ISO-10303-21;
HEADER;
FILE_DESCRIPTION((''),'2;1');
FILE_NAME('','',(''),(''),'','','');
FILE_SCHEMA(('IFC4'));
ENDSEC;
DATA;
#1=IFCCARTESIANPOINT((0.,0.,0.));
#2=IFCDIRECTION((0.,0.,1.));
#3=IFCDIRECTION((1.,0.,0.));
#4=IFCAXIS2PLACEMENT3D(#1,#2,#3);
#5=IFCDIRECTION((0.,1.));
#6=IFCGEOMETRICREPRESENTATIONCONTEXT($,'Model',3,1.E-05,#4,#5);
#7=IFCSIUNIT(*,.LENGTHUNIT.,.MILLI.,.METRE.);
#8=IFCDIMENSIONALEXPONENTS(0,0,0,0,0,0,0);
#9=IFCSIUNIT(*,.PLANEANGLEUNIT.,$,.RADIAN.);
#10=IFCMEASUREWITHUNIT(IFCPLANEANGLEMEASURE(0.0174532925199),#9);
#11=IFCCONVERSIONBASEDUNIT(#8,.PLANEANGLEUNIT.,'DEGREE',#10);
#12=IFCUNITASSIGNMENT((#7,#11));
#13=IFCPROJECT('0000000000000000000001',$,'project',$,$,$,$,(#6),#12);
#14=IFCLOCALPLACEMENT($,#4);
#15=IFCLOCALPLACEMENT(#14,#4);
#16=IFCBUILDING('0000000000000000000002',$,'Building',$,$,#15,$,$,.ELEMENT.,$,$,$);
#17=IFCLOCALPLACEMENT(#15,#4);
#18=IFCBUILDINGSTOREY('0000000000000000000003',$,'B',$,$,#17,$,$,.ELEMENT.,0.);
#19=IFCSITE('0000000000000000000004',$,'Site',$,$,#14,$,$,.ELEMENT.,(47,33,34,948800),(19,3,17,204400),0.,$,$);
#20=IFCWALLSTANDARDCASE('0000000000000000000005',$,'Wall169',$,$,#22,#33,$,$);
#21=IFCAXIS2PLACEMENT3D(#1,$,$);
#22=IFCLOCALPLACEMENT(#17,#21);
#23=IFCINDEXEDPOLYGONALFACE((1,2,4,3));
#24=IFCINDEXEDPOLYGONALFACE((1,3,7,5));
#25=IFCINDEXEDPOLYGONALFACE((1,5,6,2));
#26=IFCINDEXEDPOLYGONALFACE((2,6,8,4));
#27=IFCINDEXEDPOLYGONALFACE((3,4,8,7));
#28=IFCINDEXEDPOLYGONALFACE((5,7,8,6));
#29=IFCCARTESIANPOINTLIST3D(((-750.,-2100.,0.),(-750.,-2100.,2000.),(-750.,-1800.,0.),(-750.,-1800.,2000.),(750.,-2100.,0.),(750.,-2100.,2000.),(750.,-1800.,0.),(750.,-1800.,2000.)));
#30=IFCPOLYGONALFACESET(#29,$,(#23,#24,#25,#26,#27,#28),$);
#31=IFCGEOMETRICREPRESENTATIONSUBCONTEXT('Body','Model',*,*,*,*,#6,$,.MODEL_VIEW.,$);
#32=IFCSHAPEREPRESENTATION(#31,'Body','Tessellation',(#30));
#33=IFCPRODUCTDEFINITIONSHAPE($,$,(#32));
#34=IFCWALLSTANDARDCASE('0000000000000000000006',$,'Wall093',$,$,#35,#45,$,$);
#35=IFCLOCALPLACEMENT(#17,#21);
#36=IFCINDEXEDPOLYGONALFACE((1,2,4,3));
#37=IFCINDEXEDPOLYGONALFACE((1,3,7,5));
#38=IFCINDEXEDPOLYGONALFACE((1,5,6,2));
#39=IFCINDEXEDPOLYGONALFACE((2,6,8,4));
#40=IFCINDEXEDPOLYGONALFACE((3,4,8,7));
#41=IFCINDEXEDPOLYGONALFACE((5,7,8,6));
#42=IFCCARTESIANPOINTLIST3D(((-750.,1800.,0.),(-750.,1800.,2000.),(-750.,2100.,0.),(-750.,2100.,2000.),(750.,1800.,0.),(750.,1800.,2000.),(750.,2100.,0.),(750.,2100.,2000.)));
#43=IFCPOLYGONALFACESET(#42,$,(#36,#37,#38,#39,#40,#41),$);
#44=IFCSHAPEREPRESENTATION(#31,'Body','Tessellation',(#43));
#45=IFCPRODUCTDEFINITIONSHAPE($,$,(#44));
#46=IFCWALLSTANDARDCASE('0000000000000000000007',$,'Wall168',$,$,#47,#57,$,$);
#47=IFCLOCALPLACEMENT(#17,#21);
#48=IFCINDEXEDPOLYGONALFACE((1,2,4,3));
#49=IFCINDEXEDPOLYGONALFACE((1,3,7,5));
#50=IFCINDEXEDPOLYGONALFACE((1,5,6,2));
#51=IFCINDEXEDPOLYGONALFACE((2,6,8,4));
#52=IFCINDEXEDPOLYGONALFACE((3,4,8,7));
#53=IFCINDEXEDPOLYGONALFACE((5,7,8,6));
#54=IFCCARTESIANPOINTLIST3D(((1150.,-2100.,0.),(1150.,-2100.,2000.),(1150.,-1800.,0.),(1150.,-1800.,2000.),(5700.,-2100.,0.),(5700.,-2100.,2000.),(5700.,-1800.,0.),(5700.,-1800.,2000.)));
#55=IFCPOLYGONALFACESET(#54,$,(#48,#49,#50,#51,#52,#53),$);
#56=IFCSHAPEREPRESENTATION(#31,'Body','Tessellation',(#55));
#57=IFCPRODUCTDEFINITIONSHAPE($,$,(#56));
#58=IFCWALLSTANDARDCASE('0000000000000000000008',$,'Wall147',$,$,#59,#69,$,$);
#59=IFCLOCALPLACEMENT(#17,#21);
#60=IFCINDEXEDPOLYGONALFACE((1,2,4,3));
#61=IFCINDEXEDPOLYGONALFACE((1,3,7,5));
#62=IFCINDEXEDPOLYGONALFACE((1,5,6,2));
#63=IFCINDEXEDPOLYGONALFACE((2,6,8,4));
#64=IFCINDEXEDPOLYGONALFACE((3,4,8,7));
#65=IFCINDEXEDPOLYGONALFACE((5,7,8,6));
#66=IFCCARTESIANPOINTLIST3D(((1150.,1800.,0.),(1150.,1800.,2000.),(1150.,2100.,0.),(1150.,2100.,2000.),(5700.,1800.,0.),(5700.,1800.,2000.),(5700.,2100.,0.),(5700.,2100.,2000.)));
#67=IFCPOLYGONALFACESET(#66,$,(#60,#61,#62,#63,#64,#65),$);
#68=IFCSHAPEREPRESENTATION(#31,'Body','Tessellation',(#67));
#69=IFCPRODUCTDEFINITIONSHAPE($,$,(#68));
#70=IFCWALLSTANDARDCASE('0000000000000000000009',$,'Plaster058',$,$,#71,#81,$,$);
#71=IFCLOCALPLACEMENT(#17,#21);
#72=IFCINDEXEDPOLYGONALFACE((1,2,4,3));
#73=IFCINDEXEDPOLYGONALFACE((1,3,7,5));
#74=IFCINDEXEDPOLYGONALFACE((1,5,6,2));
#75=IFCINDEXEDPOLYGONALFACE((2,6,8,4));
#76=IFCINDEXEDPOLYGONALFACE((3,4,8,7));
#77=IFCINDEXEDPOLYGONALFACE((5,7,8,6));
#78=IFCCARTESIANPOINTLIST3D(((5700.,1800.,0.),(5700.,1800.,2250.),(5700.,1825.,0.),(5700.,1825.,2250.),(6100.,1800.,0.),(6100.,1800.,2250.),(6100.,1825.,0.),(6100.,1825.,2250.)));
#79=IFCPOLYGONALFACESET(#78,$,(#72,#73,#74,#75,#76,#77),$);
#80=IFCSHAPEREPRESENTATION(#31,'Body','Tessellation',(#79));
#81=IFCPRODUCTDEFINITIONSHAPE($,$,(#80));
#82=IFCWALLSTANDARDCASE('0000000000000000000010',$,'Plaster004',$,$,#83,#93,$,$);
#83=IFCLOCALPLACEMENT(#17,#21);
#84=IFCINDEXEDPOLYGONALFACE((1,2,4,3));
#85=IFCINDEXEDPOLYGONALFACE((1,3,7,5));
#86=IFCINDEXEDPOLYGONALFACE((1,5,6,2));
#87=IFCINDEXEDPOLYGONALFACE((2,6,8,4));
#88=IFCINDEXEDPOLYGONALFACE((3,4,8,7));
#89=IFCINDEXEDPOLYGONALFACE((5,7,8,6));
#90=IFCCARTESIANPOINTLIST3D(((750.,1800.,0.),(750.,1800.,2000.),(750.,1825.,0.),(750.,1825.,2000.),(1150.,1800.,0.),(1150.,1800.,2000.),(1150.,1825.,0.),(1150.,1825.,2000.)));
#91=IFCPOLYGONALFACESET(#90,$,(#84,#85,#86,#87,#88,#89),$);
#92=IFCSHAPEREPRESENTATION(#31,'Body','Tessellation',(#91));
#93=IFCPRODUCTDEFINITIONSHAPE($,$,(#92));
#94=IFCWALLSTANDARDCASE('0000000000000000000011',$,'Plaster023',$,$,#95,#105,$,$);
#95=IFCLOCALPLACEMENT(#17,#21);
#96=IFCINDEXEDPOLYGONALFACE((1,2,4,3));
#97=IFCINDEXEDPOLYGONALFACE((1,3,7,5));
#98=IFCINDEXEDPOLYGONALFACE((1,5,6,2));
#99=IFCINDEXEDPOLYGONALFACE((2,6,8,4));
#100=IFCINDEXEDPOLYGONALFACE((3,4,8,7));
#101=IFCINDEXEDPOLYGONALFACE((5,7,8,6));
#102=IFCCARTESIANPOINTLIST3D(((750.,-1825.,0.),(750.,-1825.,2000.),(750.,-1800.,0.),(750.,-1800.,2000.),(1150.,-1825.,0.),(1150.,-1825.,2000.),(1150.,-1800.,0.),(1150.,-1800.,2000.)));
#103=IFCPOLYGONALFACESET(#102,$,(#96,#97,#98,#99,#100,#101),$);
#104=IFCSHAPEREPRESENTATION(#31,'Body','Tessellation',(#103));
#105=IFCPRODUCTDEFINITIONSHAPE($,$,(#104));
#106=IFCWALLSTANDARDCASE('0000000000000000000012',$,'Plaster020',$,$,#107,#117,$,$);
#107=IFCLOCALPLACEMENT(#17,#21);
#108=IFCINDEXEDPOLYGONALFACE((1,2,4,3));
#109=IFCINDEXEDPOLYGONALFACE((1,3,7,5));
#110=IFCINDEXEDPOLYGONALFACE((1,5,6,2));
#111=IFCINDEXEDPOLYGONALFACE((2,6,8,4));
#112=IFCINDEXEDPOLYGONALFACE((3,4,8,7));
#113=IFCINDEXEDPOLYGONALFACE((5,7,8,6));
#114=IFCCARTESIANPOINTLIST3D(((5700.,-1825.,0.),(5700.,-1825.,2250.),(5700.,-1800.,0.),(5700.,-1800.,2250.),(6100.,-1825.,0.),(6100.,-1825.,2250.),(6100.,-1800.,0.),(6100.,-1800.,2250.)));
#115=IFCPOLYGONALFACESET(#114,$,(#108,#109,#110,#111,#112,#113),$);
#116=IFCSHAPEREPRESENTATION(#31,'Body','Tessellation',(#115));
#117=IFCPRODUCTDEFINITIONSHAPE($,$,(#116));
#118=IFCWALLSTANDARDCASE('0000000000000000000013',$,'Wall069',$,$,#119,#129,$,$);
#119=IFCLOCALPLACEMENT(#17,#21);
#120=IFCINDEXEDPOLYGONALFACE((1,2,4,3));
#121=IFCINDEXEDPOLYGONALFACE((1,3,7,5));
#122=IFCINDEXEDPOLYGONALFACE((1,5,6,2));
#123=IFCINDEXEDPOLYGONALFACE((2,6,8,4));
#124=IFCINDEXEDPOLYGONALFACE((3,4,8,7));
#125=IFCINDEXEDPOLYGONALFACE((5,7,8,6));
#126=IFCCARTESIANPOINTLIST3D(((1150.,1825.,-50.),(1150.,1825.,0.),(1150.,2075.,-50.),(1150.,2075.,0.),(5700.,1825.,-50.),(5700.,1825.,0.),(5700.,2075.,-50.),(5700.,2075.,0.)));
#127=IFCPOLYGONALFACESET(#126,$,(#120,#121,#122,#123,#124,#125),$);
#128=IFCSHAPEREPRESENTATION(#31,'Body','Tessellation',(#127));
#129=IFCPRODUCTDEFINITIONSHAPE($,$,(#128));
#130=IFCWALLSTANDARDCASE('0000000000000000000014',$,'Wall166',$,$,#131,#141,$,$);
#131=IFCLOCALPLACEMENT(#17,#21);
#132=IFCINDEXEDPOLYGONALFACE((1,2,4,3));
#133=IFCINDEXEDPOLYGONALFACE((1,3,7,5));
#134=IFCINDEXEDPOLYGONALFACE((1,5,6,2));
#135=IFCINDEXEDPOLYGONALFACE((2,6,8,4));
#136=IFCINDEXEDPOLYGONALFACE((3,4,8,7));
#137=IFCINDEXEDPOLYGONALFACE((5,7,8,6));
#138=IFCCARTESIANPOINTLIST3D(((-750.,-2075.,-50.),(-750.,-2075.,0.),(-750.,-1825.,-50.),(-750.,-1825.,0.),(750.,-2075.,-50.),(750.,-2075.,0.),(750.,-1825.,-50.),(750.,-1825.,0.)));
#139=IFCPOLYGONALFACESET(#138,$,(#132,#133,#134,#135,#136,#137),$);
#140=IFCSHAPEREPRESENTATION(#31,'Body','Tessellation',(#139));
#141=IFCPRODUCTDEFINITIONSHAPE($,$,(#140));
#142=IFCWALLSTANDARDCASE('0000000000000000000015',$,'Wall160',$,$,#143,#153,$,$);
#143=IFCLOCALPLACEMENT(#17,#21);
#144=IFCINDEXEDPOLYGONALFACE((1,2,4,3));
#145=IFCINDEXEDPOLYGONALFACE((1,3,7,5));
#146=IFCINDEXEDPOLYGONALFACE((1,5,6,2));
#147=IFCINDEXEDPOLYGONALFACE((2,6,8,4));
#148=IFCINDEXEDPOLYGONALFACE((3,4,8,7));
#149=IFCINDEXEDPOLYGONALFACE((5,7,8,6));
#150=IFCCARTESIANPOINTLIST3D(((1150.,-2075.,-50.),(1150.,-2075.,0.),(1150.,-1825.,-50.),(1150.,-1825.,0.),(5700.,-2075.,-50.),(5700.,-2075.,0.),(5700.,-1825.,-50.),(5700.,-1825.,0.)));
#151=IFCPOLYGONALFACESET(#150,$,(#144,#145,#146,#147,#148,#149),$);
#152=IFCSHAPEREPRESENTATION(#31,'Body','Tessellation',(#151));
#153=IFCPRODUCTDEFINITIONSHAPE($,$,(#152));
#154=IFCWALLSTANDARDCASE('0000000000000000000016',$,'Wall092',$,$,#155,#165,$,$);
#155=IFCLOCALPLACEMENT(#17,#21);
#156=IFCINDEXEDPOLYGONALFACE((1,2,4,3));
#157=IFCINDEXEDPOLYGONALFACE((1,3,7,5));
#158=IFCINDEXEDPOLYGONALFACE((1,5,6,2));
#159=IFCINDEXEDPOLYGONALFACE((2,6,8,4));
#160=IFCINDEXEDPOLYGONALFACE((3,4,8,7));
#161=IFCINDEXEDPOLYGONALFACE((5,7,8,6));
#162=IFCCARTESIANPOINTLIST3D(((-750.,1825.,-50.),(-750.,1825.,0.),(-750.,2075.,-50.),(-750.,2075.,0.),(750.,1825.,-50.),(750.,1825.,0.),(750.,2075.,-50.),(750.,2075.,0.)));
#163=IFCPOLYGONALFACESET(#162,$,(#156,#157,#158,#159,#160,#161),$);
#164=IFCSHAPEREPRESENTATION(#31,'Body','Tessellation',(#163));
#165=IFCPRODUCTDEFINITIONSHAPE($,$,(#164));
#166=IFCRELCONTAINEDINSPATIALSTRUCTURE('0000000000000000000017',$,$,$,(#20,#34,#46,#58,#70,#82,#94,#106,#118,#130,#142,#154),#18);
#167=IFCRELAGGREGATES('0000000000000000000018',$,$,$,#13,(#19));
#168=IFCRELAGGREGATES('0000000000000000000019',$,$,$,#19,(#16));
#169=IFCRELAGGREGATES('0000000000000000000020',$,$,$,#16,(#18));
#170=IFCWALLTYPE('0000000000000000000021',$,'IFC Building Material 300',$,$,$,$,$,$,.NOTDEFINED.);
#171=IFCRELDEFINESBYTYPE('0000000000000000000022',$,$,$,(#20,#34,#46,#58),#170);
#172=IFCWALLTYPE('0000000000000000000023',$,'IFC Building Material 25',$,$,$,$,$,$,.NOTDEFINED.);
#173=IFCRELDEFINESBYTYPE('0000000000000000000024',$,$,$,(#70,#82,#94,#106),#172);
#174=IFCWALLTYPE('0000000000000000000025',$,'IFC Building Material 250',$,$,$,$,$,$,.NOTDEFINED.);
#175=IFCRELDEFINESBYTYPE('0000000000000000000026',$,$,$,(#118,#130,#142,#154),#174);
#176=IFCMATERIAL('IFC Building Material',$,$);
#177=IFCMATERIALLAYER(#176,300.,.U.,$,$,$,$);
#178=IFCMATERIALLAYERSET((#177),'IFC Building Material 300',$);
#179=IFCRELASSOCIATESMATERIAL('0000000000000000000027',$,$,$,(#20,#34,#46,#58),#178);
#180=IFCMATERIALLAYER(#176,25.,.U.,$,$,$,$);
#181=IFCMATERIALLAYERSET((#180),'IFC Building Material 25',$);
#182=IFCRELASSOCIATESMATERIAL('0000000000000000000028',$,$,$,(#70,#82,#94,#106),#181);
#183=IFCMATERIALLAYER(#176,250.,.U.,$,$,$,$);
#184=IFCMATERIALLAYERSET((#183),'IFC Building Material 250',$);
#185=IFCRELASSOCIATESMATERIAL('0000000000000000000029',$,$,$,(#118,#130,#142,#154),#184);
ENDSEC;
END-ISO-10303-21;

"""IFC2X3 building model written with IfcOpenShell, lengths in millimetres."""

from ifc_helpers import new_model, entity, si_unit, converted_unit, direction, frame, origin_with_axes, place, context, subcontext, project, spatial, polyline, outline, extrude, material, layer, layer_set, layer_usage, type_object, element, save


model = new_model("IFC2X3")

# Units and contexts
model_context = context("Model", 3, precision=1e-05, world=origin_with_axes(), true_north=direction((0.0, 1.0)))
body_context = subcontext(model_context, "Body", "Model", "MODEL_VIEW")
ifc_project = project(units=[si_unit("LENGTHUNIT", "METRE", prefix="MILLI"), converted_unit("PLANEANGLEUNIT", "DEGREE", entity("IfcPlaneAngleMeasure", 0.0174532925199), si_unit("PLANEANGLEUNIT", "RADIAN"), dimensions=[0, 0, 0, 0, 0, 0, 0])], contexts=[model_context])

# Site, building, storey
site_placement = place(None, origin_with_axes())
site = spatial("IfcSite", under=ifc_project, at=site_placement, Name="Site", CompositionType="ELEMENT", RefLatitude=(47, 33, 34, 948800), RefLongitude=(19, 3, 17, 204400), RefElevation=0.0)
building_placement = place(site_placement, origin_with_axes())
building = spatial("IfcBuilding", under=site, at=building_placement, Name="Building", CompositionType="ELEMENT")
storey_placement = place(building_placement, origin_with_axes())
storey = spatial("IfcBuildingStorey", under=building, at=storey_placement, Name="B", CompositionType="ELEMENT", Elevation=0.0)

# Shared definitions
ifc_material = material(Name="IFC Building Material")

# Shared definitions
ifc_layer_1 = layer(ifc_material, 250.0, ventilated="UNKNOWN")
ifc_layer_set_1 = layer_set([ifc_layer_1], Name="IFC Building Material 250")

# Walls
ifc_layer_2 = layer(ifc_material, 300.0, ventilated="UNKNOWN")
ifc_layer_set_2 = layer_set([ifc_layer_2], Name="IFC Building Material 300")
ifc_layer_usage_1 = layer_usage(ifc_layer_set_2, "AXIS2", "POSITIVE", -300.0)
wall_type_1 = type_object("IfcWallType", Name="IFC Building Material 300", PredefinedType="NOTDEFINED")
wall_1_placement = place(storey_placement, frame((-750.0, -1800.0, 0.0), z_axis=(0.0, 0.0, 1.0), x_axis=(1.0, 0.0, 0.0)))
element("IfcWallStandardCase", 1, at=wall_1_placement, inside=storey, type_object=wall_type_1, material=ifc_layer_usage_1, Name="Wall169", context=body_context, shape_type="SweptSolid", body=[
    extrude(outline(polyline([(0.0, -300.0), (1500.0, -300.0), (1500.0, 0.0), (0.0, 0.0), (0.0, -300.0)])), origin_with_axes(), (0.0, 0.0, 1.0), 2000.0),
])
ifc_layer_usage_2 = layer_usage(ifc_layer_set_2, "AXIS2", "POSITIVE", 0.0)
wall_2_placement = place(storey_placement, frame((-750.0, 1800.0, 0.0), z_axis=(0.0, 0.0, 1.0), x_axis=(1.0, 0.0, 0.0)))
element("IfcWallStandardCase", 2, at=wall_2_placement, inside=storey, type_object=wall_type_1, material=ifc_layer_usage_2, Name="Wall093", context=body_context, shape_type="SweptSolid", body=[
    extrude(outline(polyline([(0.0, 0.0), (1500.0, 0.0), (1500.0, 300.0), (0.0, 300.0), (0.0, 0.0)])), origin_with_axes(), (0.0, 0.0, 1.0), 2000.0),
])
ifc_layer_usage_3 = layer_usage(ifc_layer_set_2, "AXIS2", "POSITIVE", 0.0)
wall_3_placement = place(storey_placement, frame((5700.0, -1800.0, 0.0), z_axis=(0.0, 0.0, 1.0), x_axis=(-1.0, 0.0, 0.0)))
element("IfcWallStandardCase", 3, at=wall_3_placement, inside=storey, type_object=wall_type_1, material=ifc_layer_usage_3, Name="Wall168", context=body_context, shape_type="SweptSolid", body=[
    extrude(outline(polyline([(0.0, 0.0), (4550.0, 0.0), (4550.0, 300.0), (0.0, 300.0), (0.0, 0.0)])), origin_with_axes(), (0.0, 0.0, 1.0), 2000.0),
])
ifc_layer_usage_4 = layer_usage(ifc_layer_set_2, "AXIS2", "POSITIVE", -300.0)
wall_4_placement = place(storey_placement, frame((5700.0, 1800.0, 0.0), z_axis=(0.0, 0.0, 1.0), x_axis=(-1.0, 0.0, 0.0)))
element("IfcWallStandardCase", 4, at=wall_4_placement, inside=storey, type_object=wall_type_1, material=ifc_layer_usage_4, Name="Wall147", context=body_context, shape_type="SweptSolid", body=[
    extrude(outline(polyline([(0.0, -300.0), (4550.0, -300.0), (4550.0, 0.0), (0.0, 0.0), (0.0, -300.0)])), origin_with_axes(), (0.0, 0.0, 1.0), 2000.0),
])
ifc_layer_3 = layer(ifc_material, 25.0, ventilated="UNKNOWN")
ifc_layer_set_3 = layer_set([ifc_layer_3], Name="IFC Building Material 25")
ifc_layer_usage_5 = layer_usage(ifc_layer_set_3, "AXIS2", "POSITIVE", 0.0)
wall_type_2 = type_object("IfcWallType", Name="IFC Building Material 25", PredefinedType="NOTDEFINED")
wall_5_placement = place(storey_placement, frame((5700.0, 1800.0, 0.0), z_axis=(0.0, 0.0, 1.0), x_axis=(1.0, 0.0, 0.0)))
element("IfcWallStandardCase", 5, at=wall_5_placement, inside=storey, type_object=wall_type_2, material=ifc_layer_usage_5, Name="Plaster058", context=body_context, shape_type="SweptSolid", body=[
    extrude(outline(polyline([(0.0, 0.0), (400.0, 0.0), (400.0, 25.0), (0.0, 25.0), (0.0, 0.0)])), origin_with_axes(), (0.0, 0.0, 1.0), 2250.0),
])
ifc_layer_usage_6 = layer_usage(ifc_layer_set_3, "AXIS2", "POSITIVE", 0.0)
wall_6_placement = place(storey_placement, frame((750.0, 1800.0, 0.0), z_axis=(0.0, 0.0, 1.0), x_axis=(1.0, 0.0, 0.0)))
element("IfcWallStandardCase", 6, at=wall_6_placement, inside=storey, type_object=wall_type_2, material=ifc_layer_usage_6, Name="Plaster004", context=body_context, shape_type="SweptSolid", body=[
    extrude(outline(polyline([(0.0, 0.0), (400.0, 0.0), (400.0, 25.0), (0.0, 25.0), (0.0, 0.0)])), origin_with_axes(), (0.0, 0.0, 1.0), 2000.0),
])
ifc_layer_usage_7 = layer_usage(ifc_layer_set_3, "AXIS2", "POSITIVE", -25.0)
wall_7_placement = place(storey_placement, frame((750.0, -1800.0, 0.0), z_axis=(0.0, 0.0, 1.0), x_axis=(1.0, 0.0, 0.0)))
element("IfcWallStandardCase", 7, at=wall_7_placement, inside=storey, type_object=wall_type_2, material=ifc_layer_usage_7, Name="Plaster023", context=body_context, shape_type="SweptSolid", body=[
    extrude(outline(polyline([(0.0, -25.0), (400.0, -25.0), (400.0, 0.0), (0.0, 0.0), (0.0, -25.0)])), origin_with_axes(), (0.0, 0.0, 1.0), 2000.0),
])
ifc_layer_usage_8 = layer_usage(ifc_layer_set_3, "AXIS2", "POSITIVE", -25.0)
wall_8_placement = place(storey_placement, frame((5700.0, -1800.0, 0.0), z_axis=(0.0, 0.0, 1.0), x_axis=(1.0, 0.0, 0.0)))
element("IfcWallStandardCase", 8, at=wall_8_placement, inside=storey, type_object=wall_type_2, material=ifc_layer_usage_8, Name="Plaster020", context=body_context, shape_type="SweptSolid", body=[
    extrude(outline(polyline([(0.0, -25.0), (400.0, -25.0), (400.0, 0.0), (0.0, 0.0), (0.0, -25.0)])), origin_with_axes(), (0.0, 0.0, 1.0), 2250.0),
])
ifc_layer_usage_9 = layer_usage(ifc_layer_set_1, "AXIS2", "POSITIVE", -250.0)
wall_type_3 = type_object("IfcWallType", Name="IFC Building Material 250", PredefinedType="NOTDEFINED")
wall_9_placement = place(storey_placement, frame((5700.0, 1825.0, -50.0), z_axis=(0.0, 0.0, 1.0), x_axis=(-1.0, 0.0, 0.0)))
element("IfcWallStandardCase", 9, at=wall_9_placement, inside=storey, type_object=wall_type_3, material=ifc_layer_usage_9, Name="Wall069", context=body_context, shape_type="SweptSolid", body=[
    extrude(outline(polyline([(0.0, -250.0), (4550.0, -250.0), (4550.0, 0.0), (0.0, 0.0), (0.0, -250.0)])), origin_with_axes(), (0.0, 0.0, 1.0), 50.0),
])
ifc_layer_usage_10 = layer_usage(ifc_layer_set_1, "AXIS2", "POSITIVE", -250.0)
wall_10_placement = place(storey_placement, frame((-750.0, -1825.0, -50.0), z_axis=(0.0, 0.0, 1.0), x_axis=(1.0, 0.0, 0.0)))
element("IfcWallStandardCase", 10, at=wall_10_placement, inside=storey, type_object=wall_type_3, material=ifc_layer_usage_10, Name="Wall166", context=body_context, shape_type="SweptSolid", body=[
    extrude(outline(polyline([(0.0, -250.0), (1500.0, -250.0), (1500.0, 0.0), (0.0, 0.0), (0.0, -250.0)])), origin_with_axes(), (0.0, 0.0, 1.0), 50.0),
])
ifc_layer_usage_11 = layer_usage(ifc_layer_set_1, "AXIS2", "POSITIVE", 0.0)
wall_11_placement = place(storey_placement, frame((5700.0, -1825.0, -50.0), z_axis=(0.0, 0.0, 1.0), x_axis=(-1.0, 0.0, 0.0)))
element("IfcWallStandardCase", 11, at=wall_11_placement, inside=storey, type_object=wall_type_3, material=ifc_layer_usage_11, Name="Wall160", context=body_context, shape_type="SweptSolid", body=[
    extrude(outline(polyline([(0.0, 0.0), (4550.0, 0.0), (4550.0, 250.0), (0.0, 250.0), (0.0, 0.0)])), origin_with_axes(), (0.0, 0.0, 1.0), 50.0),
])
ifc_layer_usage_12 = layer_usage(ifc_layer_set_1, "AXIS2", "POSITIVE", 0.0)
wall_12_placement = place(storey_placement, frame((-750.0, 1825.0, -50.0), z_axis=(0.0, 0.0, 1.0), x_axis=(1.0, 0.0, 0.0)))
element("IfcWallStandardCase", 12, at=wall_12_placement, inside=storey, type_object=wall_type_3, material=ifc_layer_usage_12, Name="Wall092", context=body_context, shape_type="SweptSolid", body=[
    extrude(outline(polyline([(0.0, 0.0), (1500.0, 0.0), (1500.0, 250.0), (0.0, 250.0), (0.0, 0.0)])), origin_with_axes(), (0.0, 0.0, 1.0), 50.0),
])

save(model, "model.ifc")
